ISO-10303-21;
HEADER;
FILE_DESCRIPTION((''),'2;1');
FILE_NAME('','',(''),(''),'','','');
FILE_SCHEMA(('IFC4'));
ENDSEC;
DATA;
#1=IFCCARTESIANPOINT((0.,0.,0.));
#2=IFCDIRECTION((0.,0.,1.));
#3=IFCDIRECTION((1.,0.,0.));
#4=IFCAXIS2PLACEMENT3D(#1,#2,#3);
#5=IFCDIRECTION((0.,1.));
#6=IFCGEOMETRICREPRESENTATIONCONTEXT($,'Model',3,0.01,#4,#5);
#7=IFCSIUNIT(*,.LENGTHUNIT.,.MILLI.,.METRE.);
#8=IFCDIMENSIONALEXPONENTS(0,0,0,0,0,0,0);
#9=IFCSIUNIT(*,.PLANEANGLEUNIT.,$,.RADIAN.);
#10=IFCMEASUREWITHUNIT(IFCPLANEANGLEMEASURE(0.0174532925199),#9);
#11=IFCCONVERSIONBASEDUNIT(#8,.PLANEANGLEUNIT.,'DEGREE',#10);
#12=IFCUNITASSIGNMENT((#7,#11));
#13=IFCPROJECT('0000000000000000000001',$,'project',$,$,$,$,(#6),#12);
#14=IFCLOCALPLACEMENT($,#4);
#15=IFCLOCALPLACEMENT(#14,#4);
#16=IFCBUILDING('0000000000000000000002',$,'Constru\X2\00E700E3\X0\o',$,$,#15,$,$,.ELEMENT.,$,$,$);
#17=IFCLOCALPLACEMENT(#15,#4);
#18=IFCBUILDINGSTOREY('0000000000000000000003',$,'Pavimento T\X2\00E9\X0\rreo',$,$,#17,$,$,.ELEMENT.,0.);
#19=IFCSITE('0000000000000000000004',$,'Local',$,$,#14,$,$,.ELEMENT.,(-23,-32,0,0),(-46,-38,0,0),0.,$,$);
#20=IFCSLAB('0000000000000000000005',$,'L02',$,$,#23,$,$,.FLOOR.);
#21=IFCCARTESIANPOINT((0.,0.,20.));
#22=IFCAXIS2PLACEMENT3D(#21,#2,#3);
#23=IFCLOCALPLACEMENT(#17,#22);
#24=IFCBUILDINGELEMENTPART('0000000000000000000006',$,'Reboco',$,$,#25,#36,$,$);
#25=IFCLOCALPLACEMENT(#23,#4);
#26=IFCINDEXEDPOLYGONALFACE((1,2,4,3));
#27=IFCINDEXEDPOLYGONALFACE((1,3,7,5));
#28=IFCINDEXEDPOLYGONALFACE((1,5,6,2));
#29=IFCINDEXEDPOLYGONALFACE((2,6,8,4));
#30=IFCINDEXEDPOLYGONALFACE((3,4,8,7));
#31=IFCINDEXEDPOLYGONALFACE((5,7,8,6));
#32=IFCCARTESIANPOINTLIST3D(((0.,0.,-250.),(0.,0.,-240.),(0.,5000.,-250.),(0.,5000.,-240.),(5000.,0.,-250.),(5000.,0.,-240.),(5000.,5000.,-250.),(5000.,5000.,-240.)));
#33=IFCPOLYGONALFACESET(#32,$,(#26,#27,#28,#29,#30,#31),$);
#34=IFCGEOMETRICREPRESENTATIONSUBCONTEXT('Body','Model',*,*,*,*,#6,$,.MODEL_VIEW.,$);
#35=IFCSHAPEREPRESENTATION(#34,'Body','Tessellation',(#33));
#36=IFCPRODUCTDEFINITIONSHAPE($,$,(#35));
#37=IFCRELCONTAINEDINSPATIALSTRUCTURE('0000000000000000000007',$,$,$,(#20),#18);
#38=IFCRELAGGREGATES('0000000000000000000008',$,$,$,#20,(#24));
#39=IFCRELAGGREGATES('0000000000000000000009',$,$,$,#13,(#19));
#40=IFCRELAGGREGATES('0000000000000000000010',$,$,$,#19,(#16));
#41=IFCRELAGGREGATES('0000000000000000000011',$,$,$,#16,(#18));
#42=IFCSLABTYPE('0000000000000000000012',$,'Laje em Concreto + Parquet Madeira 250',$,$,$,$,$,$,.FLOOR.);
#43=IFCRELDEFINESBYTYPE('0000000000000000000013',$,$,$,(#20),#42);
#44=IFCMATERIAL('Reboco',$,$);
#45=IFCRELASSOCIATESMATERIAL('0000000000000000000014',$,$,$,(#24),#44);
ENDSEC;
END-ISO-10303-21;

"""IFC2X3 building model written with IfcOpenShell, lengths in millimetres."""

from ifc_helpers import new_model, entity, si_unit, converted_unit, direction, frame, origin_with_axes, place, context, subcontext, project, spatial, polyline, outline, extrude, material, type_object, element, aggregate, save


model = new_model("IFC2X3")

# Units and contexts
model_context = context("Model", 3, precision=0.01, world=origin_with_axes(), true_north=direction((0.0, 1.0)))
body_context = subcontext(model_context, "Body", "Model", "MODEL_VIEW")
ifc_project = project(units=[si_unit("LENGTHUNIT", "METRE", prefix="MILLI"), converted_unit("PLANEANGLEUNIT", "DEGREE", entity("IfcPlaneAngleMeasure", 0.0174532925199), si_unit("PLANEANGLEUNIT", "RADIAN"), dimensions=[0, 0, 0, 0, 0, 0, 0])], contexts=[model_context])

# Site, building, storey
site_placement = place(None, origin_with_axes())
site = spatial("IfcSite", under=ifc_project, at=site_placement, Name="Local", CompositionType="ELEMENT", RefLatitude=(-23, -32, 0, 0), RefLongitude=(-46, -38, 0, 0), RefElevation=0.0)
building_placement = place(site_placement, origin_with_axes())
building = spatial("IfcBuilding", under=site, at=building_placement, Name="Construção", CompositionType="ELEMENT")
storey_placement = place(building_placement, origin_with_axes())
storey = spatial("IfcBuildingStorey", under=building, at=storey_placement, Name="Pavimento Térreo", CompositionType="ELEMENT", Elevation=0.0)

# Shared definitions
ifc_material_1 = material(Name="Reboco")

# Slab, building element part
slab_type = type_object("IfcSlabType", Name="Laje em Concreto + Parquet Madeira 250", PredefinedType="FLOOR")
slab_placement = place(storey_placement, frame((0.0, 0.0, 20.0), z_axis=(0.0, 0.0, 1.0), x_axis=(1.0, 0.0, 0.0)))
slab = element("IfcSlab", 1, at=slab_placement, inside=storey, type_object=slab_type, Name="L02", PredefinedType="FLOOR")
building_element_part_1_placement = place(slab_placement, origin_with_axes())
building_element_part_1 = element("IfcBuildingElementPart", 2, at=building_element_part_1_placement, material=ifc_material_1, Name="Reboco", context=body_context, shape_type="SweptSolid", body=[
    extrude(outline(polyline([(0.0, 0.0), (5000.0, 0.0), (5000.0, 5000.0), (0.0, 5000.0), (0.0, 0.0)])), frame((0.0, 0.0, -250.0), z_axis=(0.0, 0.0, 1.0), x_axis=(1.0, 0.0, 0.0)), (0.0, 0.0, 1.0), 10.0),
])
aggregate(slab, [building_element_part_1])

save(model, "model.ifc")
